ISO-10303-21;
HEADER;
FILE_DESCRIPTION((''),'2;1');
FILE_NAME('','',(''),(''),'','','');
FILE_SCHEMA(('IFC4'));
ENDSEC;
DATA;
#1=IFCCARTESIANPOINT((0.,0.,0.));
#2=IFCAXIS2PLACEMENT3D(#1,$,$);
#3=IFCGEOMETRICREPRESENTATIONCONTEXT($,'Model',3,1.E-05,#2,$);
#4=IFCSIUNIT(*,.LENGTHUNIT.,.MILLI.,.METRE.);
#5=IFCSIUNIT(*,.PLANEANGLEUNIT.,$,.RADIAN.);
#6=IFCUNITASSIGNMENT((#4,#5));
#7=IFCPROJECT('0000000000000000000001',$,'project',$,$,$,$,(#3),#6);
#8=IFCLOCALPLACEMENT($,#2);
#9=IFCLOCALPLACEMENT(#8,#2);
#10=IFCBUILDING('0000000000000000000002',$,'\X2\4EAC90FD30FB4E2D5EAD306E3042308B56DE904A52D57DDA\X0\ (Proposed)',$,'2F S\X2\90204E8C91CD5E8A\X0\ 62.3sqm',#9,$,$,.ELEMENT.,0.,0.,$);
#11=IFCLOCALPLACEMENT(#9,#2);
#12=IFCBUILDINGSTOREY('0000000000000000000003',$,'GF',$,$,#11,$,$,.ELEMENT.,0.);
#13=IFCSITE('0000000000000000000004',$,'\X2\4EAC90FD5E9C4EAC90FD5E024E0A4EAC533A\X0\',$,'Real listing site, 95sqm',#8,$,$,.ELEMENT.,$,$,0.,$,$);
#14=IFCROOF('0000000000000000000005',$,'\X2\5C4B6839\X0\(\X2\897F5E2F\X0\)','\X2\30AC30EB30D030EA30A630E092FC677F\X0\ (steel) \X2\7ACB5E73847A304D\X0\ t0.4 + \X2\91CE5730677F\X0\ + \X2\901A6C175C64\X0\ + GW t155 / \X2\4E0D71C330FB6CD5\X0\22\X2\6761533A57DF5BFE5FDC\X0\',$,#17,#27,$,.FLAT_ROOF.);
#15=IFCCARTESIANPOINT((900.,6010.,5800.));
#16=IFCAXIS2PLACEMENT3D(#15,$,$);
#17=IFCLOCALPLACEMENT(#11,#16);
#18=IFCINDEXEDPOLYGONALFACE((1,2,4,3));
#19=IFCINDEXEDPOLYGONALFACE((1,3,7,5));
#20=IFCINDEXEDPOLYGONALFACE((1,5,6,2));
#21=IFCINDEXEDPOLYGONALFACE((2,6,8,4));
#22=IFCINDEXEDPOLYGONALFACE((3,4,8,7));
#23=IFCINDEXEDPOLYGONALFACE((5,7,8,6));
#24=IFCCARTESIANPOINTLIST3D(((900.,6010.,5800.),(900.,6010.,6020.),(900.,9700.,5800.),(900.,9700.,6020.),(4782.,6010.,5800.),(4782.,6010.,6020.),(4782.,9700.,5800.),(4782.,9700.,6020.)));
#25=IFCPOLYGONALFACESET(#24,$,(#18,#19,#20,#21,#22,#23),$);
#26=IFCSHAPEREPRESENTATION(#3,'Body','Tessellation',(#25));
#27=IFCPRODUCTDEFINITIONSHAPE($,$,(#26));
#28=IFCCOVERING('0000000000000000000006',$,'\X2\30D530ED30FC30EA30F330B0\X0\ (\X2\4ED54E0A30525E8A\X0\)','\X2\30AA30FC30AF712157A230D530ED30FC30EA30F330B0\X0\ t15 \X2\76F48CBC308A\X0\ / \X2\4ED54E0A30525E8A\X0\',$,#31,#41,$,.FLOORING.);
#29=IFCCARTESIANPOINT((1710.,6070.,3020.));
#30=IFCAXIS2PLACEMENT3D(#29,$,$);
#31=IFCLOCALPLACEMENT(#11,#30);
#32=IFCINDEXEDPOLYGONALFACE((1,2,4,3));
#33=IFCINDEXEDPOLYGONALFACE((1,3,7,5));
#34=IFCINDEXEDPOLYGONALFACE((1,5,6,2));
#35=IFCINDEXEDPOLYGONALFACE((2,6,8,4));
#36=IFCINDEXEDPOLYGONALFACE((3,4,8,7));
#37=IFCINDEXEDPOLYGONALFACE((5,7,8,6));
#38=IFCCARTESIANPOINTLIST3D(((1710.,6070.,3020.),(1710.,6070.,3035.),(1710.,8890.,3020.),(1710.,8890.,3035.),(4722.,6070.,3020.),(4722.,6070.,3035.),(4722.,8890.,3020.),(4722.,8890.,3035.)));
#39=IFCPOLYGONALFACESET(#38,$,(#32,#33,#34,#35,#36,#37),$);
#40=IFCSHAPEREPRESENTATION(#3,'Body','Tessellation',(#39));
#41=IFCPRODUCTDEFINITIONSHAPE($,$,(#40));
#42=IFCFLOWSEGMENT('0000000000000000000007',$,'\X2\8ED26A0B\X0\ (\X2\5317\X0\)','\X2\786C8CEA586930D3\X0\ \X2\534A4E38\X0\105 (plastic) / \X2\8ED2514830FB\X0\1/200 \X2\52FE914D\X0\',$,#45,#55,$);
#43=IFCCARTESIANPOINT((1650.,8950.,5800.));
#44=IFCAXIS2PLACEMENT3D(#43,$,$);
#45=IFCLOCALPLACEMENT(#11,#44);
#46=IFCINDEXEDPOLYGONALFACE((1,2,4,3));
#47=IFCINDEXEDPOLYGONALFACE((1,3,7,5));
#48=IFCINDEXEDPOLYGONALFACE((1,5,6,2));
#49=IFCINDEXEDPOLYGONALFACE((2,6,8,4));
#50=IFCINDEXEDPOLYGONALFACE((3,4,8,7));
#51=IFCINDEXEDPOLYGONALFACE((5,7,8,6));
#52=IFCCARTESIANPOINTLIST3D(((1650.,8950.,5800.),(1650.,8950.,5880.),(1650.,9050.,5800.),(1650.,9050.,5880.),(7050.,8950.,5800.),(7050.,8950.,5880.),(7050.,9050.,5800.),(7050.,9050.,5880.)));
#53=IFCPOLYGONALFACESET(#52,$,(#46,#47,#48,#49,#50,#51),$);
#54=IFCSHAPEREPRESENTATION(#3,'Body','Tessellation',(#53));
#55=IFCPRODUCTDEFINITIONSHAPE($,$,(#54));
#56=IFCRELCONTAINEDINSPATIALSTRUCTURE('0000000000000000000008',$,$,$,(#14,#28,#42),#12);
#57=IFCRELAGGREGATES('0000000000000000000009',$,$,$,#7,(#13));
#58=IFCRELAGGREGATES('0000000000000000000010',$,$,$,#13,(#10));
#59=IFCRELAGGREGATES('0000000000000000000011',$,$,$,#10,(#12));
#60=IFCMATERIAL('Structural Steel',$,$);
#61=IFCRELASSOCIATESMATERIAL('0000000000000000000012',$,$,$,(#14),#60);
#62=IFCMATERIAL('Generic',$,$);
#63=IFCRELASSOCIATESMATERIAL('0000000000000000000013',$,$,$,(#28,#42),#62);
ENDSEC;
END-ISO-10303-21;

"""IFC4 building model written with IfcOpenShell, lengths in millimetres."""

from ifc_helpers import new_model, si_unit, frame, frame_2d, origin, place, context, project, spatial, rectangle, extrude, material, element, save


model = new_model("IFC4")

# Units and contexts
model_context = context("Model", 3, precision=1e-05, world=origin())
ifc_project = project(units=[si_unit("LENGTHUNIT", "METRE", prefix="MILLI"), si_unit("PLANEANGLEUNIT", "RADIAN")], contexts=[model_context])

# Site, building, storey
site_placement = place(None, origin())
site = spatial("IfcSite", under=ifc_project, at=site_placement, Name="京都府京都市上京区", ObjectType="Real listing site, 95sqm", CompositionType="ELEMENT", RefElevation=0.0)
building_placement = place(site_placement, origin())
building = spatial("IfcBuilding", under=site, at=building_placement, Name="京都・中庭のある回遊動線 (Proposed)", ObjectType="2F S造二重床 62.3sqm", CompositionType="ELEMENT", ElevationOfRefHeight=0.0, ElevationOfTerrain=0.0)
storey_placement = place(building_placement, origin())
storey = spatial("IfcBuildingStorey", under=building, at=storey_placement, Name="GF", CompositionType="ELEMENT", Elevation=0.0)

# Roof
ifc_material_1 = material(Name="Structural Steel")
for number, where, name in (
    (1, (900.0, 6010.0, 5800.0), "屋根(西帯)"),
):
    element("IfcRoof", number, at=place(storey_placement, frame(where)), inside=storey, material=ifc_material_1, Name=name, Description="ガルバリウム鋼板 (steel) 立平葺き t0.4 + 野地板 + 通気層 + GW t155 / 不燃・法22条区域対応", PredefinedType="FLAT_ROOF", context=model_context, shape_type="SweptSolid", body=[
        extrude(rectangle(XDim=3882.0, YDim=3690.0, at=frame_2d((1941.0, 1845.0))), frame((900.0, 6010.0, 5800.0)), (0.0, 0.0, 1.0), 220.0),
    ])

# Covering
ifc_material_2 = material(Name="Generic")
covering_placement = place(storey_placement, frame((1710.0, 6070.0, 3020.0)))
element("IfcCovering", 2, at=covering_placement, inside=storey, material=ifc_material_2, Name="フローリング (仕上げ床)", Description="オーク無垢フローリング t15 直貼り / 仕上げ床", PredefinedType="FLOORING", context=model_context, shape_type="SweptSolid", body=[
    extrude(rectangle(XDim=3012.0, YDim=2820.0, at=frame_2d((1506.0, 1410.0))), frame((1710.0, 6070.0, 3020.0)), (0.0, 0.0, 1.0), 15.0),
])

# Flow segment
flow_segment_placement = place(storey_placement, frame((1650.0, 8950.0, 5800.0)))
element("IfcFlowSegment", 3, at=flow_segment_placement, inside=storey, material=ifc_material_2, Name="軒樋 (北)", Description="硬質塩ビ 半丸105 (plastic) / 軒先・1/200 勾配", context=model_context, shape_type="SweptSolid", body=[
    extrude(rectangle(XDim=5400.0, YDim=100.0, at=frame_2d((2700.0, 50.0))), frame((1650.0, 8950.0, 5800.0)), (0.0, 0.0, 1.0), 80.0),
])

save(model, "model.ifc")
